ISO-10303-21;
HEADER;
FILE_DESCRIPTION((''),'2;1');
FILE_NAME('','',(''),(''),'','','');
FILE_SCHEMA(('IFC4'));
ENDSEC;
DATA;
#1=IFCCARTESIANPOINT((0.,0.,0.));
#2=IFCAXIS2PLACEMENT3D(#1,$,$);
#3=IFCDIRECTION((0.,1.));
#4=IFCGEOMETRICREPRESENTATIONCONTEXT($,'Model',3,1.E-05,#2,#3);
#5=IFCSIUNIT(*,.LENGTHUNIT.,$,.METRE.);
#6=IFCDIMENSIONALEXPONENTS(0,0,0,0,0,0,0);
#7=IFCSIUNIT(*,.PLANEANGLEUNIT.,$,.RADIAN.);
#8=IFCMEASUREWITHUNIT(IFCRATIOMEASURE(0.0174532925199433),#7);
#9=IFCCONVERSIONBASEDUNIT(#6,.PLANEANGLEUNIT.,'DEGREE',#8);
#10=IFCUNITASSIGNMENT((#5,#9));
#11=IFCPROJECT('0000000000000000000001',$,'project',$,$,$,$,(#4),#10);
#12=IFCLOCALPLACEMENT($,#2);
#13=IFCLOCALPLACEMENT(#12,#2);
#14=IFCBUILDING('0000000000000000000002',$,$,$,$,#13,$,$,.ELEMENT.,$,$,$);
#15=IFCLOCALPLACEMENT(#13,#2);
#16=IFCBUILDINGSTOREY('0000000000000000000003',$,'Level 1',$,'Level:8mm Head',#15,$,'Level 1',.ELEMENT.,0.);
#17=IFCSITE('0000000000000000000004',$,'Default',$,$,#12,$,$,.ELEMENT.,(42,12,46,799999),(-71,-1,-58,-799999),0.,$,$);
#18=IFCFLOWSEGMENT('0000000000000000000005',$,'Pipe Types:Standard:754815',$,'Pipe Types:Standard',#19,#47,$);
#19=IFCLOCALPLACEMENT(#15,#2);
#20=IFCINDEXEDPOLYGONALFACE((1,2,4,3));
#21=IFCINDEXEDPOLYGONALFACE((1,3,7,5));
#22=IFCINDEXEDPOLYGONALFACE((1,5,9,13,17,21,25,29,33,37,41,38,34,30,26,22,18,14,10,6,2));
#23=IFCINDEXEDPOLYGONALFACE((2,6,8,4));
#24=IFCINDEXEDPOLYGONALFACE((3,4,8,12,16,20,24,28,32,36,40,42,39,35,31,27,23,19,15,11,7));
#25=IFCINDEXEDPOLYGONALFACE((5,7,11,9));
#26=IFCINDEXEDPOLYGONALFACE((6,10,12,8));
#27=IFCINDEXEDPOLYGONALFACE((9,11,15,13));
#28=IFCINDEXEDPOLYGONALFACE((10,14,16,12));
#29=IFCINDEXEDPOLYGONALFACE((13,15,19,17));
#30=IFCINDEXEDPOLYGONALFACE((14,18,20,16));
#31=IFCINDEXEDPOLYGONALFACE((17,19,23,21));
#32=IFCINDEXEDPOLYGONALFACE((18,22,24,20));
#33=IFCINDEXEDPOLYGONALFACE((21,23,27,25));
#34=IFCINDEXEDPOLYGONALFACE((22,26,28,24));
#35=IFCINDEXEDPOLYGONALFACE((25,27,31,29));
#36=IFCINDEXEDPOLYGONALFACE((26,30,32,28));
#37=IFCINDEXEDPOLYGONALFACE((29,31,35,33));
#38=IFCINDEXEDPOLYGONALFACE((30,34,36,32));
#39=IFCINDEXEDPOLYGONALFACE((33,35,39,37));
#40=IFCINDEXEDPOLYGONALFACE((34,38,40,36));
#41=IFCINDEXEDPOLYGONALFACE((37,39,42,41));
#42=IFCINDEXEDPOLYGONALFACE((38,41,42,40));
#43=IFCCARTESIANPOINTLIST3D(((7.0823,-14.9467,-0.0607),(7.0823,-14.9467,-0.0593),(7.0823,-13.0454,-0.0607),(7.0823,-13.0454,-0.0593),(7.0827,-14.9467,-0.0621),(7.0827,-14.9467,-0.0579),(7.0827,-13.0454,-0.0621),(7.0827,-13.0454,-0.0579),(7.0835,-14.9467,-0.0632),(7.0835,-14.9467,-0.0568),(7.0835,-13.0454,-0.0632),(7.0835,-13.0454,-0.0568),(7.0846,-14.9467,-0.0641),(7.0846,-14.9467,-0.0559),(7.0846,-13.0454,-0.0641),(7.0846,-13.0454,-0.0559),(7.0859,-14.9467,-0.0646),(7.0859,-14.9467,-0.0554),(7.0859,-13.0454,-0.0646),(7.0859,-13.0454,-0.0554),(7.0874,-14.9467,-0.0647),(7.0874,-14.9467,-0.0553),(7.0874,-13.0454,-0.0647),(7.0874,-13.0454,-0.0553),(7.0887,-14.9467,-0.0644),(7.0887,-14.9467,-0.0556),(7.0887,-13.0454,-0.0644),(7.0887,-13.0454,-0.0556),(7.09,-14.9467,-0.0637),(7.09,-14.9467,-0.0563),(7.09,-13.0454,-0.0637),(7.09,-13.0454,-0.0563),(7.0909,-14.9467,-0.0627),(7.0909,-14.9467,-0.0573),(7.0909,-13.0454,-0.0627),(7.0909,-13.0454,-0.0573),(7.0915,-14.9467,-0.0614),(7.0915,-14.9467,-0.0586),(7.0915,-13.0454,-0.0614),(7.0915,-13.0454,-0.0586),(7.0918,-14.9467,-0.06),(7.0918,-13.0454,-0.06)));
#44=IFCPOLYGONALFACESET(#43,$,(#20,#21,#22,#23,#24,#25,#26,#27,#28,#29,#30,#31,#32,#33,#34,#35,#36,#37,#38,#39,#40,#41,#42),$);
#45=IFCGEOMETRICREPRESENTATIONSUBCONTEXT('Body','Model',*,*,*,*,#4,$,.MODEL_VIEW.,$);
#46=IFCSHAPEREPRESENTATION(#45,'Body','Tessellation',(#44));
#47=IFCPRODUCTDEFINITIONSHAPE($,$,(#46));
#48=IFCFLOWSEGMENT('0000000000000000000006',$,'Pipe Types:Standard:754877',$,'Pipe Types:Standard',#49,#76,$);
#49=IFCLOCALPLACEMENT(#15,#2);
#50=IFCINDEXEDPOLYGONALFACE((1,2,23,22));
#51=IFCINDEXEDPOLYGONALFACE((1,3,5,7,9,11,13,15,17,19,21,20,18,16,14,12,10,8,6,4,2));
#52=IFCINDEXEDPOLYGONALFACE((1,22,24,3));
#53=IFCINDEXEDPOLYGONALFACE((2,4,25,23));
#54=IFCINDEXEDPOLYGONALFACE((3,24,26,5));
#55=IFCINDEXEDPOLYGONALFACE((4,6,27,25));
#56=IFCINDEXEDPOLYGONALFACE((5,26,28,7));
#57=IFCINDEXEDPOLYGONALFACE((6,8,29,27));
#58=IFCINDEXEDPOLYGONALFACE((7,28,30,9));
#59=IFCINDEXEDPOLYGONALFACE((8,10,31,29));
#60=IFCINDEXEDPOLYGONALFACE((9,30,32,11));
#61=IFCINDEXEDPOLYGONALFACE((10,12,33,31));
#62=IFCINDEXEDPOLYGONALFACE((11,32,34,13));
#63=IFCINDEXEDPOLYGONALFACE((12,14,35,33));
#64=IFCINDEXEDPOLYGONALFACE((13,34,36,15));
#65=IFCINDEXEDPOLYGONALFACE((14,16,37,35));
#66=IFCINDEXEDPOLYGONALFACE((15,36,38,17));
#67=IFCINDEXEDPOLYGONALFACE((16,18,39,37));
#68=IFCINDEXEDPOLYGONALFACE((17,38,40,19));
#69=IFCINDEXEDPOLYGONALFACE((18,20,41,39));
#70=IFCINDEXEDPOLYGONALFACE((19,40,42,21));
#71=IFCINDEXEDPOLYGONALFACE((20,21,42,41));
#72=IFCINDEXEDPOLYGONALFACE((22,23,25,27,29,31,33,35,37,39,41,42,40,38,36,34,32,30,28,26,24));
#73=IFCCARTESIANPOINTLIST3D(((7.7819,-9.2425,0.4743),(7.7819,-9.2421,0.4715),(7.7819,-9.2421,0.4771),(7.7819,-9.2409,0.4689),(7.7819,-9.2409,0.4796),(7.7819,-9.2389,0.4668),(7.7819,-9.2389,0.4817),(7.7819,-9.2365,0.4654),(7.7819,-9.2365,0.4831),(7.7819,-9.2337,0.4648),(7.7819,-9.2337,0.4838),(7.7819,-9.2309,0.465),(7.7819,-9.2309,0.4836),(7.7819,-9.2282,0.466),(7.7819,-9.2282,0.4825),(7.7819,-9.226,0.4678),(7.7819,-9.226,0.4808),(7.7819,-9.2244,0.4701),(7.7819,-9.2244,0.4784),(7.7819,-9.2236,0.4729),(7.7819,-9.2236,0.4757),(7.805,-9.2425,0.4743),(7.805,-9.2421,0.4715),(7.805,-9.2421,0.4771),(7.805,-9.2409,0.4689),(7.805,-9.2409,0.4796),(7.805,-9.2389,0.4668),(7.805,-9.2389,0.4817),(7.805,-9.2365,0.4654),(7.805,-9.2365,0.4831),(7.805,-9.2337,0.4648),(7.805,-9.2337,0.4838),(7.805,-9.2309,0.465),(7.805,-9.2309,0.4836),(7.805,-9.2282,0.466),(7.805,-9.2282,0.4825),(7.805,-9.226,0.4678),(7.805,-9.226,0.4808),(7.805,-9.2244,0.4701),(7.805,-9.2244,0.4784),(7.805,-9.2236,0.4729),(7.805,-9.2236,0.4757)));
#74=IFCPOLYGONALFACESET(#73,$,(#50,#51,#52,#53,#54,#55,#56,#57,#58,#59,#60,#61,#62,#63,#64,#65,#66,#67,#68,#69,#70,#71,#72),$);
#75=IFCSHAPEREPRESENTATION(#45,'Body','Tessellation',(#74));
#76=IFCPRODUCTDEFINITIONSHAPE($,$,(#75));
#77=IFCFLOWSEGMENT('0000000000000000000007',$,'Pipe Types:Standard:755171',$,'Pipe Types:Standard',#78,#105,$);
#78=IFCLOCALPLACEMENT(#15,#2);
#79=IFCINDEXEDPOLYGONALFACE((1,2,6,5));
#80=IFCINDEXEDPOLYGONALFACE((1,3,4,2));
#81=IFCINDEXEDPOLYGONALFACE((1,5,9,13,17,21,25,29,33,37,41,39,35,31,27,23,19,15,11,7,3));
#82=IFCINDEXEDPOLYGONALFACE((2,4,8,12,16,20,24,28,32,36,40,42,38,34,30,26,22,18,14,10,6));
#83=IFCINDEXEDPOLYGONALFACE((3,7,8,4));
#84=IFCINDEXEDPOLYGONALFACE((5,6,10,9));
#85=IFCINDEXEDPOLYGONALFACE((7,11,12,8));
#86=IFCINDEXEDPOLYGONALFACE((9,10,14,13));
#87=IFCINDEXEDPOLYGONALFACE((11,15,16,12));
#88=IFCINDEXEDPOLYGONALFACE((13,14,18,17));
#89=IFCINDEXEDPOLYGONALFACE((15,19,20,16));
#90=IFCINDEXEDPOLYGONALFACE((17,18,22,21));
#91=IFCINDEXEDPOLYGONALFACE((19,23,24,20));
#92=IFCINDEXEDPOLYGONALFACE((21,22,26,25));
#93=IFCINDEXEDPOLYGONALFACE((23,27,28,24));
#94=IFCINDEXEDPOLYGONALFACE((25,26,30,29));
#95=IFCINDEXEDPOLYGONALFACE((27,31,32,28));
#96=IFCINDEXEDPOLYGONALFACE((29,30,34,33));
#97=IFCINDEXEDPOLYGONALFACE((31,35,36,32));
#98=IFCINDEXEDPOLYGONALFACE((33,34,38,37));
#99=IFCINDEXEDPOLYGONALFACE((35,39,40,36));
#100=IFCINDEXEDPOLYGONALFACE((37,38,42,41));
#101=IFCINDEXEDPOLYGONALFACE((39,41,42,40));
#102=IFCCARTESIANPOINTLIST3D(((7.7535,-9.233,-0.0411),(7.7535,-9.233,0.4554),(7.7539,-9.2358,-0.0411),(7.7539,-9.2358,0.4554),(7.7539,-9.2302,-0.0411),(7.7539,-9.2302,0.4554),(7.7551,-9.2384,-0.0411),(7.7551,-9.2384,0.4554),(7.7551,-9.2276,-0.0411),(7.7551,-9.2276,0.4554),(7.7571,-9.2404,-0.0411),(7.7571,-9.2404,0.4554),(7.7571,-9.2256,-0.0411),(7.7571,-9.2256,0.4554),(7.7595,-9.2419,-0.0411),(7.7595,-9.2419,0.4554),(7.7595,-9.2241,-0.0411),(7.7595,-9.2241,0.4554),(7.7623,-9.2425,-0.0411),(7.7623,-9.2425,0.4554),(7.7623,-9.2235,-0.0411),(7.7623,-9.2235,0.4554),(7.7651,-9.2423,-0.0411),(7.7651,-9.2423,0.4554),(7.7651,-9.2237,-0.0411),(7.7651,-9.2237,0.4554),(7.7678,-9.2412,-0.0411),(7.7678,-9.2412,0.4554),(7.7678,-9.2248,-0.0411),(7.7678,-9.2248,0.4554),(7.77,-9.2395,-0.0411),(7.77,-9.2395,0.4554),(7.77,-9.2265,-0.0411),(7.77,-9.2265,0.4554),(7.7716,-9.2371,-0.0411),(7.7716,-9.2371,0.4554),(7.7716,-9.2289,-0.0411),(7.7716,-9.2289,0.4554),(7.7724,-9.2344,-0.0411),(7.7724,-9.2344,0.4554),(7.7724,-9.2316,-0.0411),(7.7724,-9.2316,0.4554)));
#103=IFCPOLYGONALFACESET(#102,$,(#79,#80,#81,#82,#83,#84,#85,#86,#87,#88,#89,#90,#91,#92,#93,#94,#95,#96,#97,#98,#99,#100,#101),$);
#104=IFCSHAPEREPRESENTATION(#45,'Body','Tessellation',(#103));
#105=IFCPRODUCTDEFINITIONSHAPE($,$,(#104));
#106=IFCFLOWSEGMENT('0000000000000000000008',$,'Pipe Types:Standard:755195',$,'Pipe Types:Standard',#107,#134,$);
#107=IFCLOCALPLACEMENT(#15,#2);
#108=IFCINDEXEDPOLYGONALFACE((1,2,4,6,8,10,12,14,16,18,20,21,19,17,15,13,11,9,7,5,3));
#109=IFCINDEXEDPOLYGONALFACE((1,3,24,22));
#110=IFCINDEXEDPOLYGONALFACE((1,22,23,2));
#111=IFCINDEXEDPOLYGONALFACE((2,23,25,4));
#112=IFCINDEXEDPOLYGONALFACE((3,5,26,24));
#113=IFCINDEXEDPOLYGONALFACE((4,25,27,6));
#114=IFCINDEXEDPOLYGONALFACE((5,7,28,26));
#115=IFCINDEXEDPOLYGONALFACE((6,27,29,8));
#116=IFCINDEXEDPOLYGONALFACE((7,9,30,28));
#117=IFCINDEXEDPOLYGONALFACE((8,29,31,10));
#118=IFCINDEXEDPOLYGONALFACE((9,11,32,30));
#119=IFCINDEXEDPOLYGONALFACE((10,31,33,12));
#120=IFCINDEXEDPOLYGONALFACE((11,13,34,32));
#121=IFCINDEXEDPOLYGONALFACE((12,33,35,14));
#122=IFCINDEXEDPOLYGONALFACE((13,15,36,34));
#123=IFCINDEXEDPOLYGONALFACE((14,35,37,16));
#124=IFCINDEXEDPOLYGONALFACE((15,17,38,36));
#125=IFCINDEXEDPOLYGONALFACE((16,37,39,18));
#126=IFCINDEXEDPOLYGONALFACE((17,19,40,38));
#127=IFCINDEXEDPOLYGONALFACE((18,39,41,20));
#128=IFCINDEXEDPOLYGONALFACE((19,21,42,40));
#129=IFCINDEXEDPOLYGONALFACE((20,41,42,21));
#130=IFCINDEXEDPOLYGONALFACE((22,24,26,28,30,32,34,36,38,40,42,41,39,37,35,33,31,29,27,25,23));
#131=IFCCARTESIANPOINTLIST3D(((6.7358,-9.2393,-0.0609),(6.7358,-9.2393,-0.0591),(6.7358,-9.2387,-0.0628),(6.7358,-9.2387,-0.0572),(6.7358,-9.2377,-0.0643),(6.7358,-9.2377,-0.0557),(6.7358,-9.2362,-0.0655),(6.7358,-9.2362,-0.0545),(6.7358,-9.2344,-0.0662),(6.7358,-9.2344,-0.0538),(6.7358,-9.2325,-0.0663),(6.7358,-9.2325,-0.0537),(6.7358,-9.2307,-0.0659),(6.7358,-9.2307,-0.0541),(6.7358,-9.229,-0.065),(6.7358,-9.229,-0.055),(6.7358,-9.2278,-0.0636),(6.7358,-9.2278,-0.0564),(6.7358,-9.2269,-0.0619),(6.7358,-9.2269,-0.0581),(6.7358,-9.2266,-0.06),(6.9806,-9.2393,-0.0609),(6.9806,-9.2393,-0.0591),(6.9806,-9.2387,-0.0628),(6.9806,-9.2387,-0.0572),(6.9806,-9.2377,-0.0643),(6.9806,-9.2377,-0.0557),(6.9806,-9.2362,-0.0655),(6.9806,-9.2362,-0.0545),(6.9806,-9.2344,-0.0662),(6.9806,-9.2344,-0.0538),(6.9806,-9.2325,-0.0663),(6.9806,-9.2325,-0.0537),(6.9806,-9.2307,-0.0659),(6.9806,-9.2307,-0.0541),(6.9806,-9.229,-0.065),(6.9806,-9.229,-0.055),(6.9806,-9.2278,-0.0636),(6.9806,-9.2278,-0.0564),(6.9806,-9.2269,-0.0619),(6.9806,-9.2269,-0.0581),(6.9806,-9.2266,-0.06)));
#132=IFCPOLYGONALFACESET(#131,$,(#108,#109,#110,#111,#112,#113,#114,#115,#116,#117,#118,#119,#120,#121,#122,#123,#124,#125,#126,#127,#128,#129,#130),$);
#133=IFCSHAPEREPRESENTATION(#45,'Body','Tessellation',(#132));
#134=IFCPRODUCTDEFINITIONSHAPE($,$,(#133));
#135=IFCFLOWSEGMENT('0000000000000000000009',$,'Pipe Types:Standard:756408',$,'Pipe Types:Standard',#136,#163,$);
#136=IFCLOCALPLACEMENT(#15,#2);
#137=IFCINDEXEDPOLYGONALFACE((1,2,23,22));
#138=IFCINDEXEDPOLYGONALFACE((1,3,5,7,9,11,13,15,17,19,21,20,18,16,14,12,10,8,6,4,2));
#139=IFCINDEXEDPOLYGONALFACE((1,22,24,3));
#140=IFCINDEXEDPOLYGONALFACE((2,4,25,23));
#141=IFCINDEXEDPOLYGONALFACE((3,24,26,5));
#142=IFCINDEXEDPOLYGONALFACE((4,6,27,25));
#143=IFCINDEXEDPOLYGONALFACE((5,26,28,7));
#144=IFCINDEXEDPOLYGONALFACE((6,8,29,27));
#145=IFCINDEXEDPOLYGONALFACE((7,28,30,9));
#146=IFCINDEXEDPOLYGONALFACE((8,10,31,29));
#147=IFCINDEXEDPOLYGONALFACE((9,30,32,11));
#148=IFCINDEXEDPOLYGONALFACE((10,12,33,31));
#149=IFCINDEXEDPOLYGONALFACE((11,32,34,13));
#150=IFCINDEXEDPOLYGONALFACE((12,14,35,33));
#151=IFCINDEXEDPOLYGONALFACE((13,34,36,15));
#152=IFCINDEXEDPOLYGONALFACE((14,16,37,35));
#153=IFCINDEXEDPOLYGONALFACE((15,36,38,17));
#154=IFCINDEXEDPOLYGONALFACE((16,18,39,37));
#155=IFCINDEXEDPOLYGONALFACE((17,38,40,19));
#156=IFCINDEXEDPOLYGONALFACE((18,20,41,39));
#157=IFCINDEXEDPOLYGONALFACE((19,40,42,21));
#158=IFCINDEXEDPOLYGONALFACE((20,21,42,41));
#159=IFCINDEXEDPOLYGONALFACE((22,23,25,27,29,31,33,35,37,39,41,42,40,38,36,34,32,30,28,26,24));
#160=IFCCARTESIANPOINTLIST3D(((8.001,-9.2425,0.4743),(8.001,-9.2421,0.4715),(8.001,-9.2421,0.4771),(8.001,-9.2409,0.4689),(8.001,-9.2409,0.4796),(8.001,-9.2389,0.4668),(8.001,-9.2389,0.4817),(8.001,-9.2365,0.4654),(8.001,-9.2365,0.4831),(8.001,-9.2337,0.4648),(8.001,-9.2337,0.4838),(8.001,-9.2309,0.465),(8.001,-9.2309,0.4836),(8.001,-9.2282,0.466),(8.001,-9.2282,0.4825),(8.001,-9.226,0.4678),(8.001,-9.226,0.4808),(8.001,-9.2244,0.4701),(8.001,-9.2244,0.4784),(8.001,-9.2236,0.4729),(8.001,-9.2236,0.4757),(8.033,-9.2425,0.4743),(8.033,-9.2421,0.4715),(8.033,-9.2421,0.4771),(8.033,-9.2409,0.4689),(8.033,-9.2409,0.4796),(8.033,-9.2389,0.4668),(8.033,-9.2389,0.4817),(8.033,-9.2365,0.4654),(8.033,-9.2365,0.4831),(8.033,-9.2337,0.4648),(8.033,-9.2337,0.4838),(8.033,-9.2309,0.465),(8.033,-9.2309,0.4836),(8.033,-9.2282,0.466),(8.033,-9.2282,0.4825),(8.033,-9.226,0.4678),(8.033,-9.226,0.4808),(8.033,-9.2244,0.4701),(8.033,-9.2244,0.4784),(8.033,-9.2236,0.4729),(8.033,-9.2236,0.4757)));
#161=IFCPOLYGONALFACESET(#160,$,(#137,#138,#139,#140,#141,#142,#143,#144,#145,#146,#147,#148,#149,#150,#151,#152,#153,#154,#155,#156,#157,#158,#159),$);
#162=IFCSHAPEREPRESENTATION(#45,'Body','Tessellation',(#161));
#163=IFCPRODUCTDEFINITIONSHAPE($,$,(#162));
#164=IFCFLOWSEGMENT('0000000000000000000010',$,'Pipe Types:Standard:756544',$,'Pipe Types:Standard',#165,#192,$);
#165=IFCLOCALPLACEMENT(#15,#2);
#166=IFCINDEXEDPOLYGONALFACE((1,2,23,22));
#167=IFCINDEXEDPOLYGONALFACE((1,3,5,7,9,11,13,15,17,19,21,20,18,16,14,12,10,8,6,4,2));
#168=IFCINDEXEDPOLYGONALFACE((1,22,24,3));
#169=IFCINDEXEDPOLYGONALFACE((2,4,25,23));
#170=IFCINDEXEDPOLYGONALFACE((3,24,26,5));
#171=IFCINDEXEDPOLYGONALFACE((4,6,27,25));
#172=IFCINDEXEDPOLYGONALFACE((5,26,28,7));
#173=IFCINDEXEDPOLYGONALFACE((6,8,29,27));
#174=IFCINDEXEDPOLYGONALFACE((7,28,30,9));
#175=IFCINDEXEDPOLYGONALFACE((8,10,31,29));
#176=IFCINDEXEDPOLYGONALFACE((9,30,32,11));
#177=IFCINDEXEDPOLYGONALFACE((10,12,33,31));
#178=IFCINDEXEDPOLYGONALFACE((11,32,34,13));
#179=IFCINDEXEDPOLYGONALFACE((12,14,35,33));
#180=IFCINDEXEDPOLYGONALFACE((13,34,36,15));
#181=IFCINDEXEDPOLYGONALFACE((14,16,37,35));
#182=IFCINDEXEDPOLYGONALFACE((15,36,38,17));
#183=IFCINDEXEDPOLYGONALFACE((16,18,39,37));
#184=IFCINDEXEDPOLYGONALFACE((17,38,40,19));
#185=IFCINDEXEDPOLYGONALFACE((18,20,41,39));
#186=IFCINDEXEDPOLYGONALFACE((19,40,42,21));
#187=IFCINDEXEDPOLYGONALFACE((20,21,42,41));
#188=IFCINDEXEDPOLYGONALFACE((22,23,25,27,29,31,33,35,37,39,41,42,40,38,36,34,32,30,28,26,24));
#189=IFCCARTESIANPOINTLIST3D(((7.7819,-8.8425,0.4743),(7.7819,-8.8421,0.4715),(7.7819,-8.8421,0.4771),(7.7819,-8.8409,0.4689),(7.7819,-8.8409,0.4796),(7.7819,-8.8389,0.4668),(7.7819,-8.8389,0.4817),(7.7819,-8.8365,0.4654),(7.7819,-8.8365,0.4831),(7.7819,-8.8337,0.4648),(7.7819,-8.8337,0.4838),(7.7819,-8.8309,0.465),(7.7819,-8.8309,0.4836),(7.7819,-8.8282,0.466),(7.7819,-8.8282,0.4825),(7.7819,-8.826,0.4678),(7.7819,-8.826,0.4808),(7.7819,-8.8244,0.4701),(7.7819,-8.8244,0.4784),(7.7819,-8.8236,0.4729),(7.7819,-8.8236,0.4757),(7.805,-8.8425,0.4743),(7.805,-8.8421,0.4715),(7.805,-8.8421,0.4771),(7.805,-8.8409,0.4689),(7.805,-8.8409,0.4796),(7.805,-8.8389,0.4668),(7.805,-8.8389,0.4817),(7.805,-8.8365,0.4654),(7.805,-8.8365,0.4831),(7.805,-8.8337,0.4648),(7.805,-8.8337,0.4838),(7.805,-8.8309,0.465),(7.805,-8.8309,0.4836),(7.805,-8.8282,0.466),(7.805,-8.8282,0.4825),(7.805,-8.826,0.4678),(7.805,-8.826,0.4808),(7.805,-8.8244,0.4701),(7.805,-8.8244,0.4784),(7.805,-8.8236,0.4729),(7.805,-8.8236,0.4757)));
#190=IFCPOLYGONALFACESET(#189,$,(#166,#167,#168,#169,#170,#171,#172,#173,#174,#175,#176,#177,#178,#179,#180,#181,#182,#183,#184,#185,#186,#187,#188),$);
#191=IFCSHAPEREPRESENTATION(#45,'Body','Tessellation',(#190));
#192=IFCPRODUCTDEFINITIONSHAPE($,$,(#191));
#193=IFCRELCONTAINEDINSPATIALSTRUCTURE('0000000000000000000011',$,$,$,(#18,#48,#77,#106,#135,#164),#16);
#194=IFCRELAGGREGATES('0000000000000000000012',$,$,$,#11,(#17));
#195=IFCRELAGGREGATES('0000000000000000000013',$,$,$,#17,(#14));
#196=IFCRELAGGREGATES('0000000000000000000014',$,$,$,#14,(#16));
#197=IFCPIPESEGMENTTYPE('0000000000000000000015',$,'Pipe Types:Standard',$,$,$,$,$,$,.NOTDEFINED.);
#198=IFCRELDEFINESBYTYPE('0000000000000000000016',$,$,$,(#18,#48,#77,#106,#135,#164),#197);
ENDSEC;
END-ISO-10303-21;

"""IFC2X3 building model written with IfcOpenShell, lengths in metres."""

from ifc_helpers import new_model, entity, si_unit, converted_unit, direction, frame, frame_2d, origin, origin_2d_with_axis, place, context, subcontext, project, spatial, circle, extrude, type_object, element, save


model = new_model("IFC2X3")

# Units and contexts
model_context = context("Model", 3, precision=1e-05, world=origin(), true_north=direction((0.0, 1.0)))
body_context = subcontext(model_context, "Body", "Model", "MODEL_VIEW")
ifc_project = project(units=[si_unit("LENGTHUNIT", "METRE"), converted_unit("PLANEANGLEUNIT", "DEGREE", entity("IfcRatioMeasure", 0.0174532925199433), si_unit("PLANEANGLEUNIT", "RADIAN"), dimensions=[0, 0, 0, 0, 0, 0, 0])], contexts=[model_context])

# Site, building, storey
site_placement = place(None, origin())
site = spatial("IfcSite", under=ifc_project, at=site_placement, Name="Default", CompositionType="ELEMENT", RefLatitude=(42, 12, 46, 799999), RefLongitude=(-71, -1, -58, -799999), RefElevation=0.0)
building_placement = place(site_placement, origin())
building = spatial("IfcBuilding", under=site, at=building_placement, CompositionType="ELEMENT")
storey_placement = place(building_placement, origin())
storey = spatial("IfcBuildingStorey", under=building, at=storey_placement, Name="Level 1", ObjectType="Level:8mm Head", LongName="Level 1", CompositionType="ELEMENT", Elevation=0.0)

# Flow segments
pipe_segment_type = type_object("IfcPipeSegmentType", Name="Pipe Types:Standard", PredefinedType="NOTDEFINED")
flow_segment_1_placement = place(storey_placement, origin())
element("IfcFlowSegment", 1, at=flow_segment_1_placement, inside=storey, type_object=pipe_segment_type, Name="Pipe Types:Standard:754815", ObjectType="Pipe Types:Standard", context=body_context, shape_type="SweptSolid", body=[
    extrude(circle(Radius=0.0048, at=frame_2d((0.0, 0.0), x_axis=(1.0, 0.0))), frame((7.087, -14.9467, -0.06), z_axis=(0.0, 1.0, 0.0), x_axis=(1.0, 0.0, 0.0)), (0.0, 0.0, 1.0), 1.9012),
])
flow_segment_2_placement = place(storey_placement, origin())
element("IfcFlowSegment", 2, at=flow_segment_2_placement, inside=storey, type_object=pipe_segment_type, Name="Pipe Types:Standard:754877", ObjectType="Pipe Types:Standard", context=body_context, shape_type="SweptSolid", body=[
    extrude(circle(Radius=0.0095, at=origin_2d_with_axis()), frame((7.7819, -9.233, 0.4743), z_axis=(1.0, 0.0, 0.0), x_axis=(0.0, -1.0, 0.0)), (0.0, 0.0, 1.0), 0.0231),
])
flow_segment_3_placement = place(storey_placement, origin())
element("IfcFlowSegment", 3, at=flow_segment_3_placement, inside=storey, type_object=pipe_segment_type, Name="Pipe Types:Standard:755171", ObjectType="Pipe Types:Standard", context=body_context, shape_type="SweptSolid", body=[
    extrude(circle(Radius=0.0095, at=origin_2d_with_axis()), frame((7.763, -9.233, -0.0411), z_axis=(0.0, 0.0, 1.0), x_axis=(-1.0, 0.0, 0.0)), (0.0, 0.0, 1.0), 0.4965),
])
flow_segment_4_placement = place(storey_placement, origin())
element("IfcFlowSegment", 4, at=flow_segment_4_placement, inside=storey, type_object=pipe_segment_type, Name="Pipe Types:Standard:755195", ObjectType="Pipe Types:Standard", context=body_context, shape_type="SweptSolid", body=[
    extrude(circle(Radius=0.0063, at=frame_2d((0.0, 0.0), x_axis=(1.0, 0.0))), frame((6.7358, -9.233, -0.06), z_axis=(1.0, 0.0, 0.0), x_axis=(0.0, 1.0, 0.0)), (0.0, 0.0, 1.0), 0.2448),
])
flow_segment_5_placement = place(storey_placement, origin())
element("IfcFlowSegment", 5, at=flow_segment_5_placement, inside=storey, type_object=pipe_segment_type, Name="Pipe Types:Standard:756408", ObjectType="Pipe Types:Standard", context=body_context, shape_type="SweptSolid", body=[
    extrude(circle(Radius=0.0095, at=origin_2d_with_axis()), frame((8.001, -9.233, 0.4743), z_axis=(1.0, 0.0, 0.0), x_axis=(0.0, -1.0, 0.0)), (0.0, 0.0, 1.0), 0.032),
])
flow_segment_6_placement = place(storey_placement, origin())
element("IfcFlowSegment", 6, at=flow_segment_6_placement, inside=storey, type_object=pipe_segment_type, Name="Pipe Types:Standard:756544", ObjectType="Pipe Types:Standard", context=body_context, shape_type="SweptSolid", body=[
    extrude(circle(Radius=0.0095, at=origin_2d_with_axis()), frame((7.7819, -8.833, 0.4743), z_axis=(1.0, 0.0, 0.0), x_axis=(0.0, -1.0, 0.0)), (0.0, 0.0, 1.0), 0.0231),
])

save(model, "model.ifc")
